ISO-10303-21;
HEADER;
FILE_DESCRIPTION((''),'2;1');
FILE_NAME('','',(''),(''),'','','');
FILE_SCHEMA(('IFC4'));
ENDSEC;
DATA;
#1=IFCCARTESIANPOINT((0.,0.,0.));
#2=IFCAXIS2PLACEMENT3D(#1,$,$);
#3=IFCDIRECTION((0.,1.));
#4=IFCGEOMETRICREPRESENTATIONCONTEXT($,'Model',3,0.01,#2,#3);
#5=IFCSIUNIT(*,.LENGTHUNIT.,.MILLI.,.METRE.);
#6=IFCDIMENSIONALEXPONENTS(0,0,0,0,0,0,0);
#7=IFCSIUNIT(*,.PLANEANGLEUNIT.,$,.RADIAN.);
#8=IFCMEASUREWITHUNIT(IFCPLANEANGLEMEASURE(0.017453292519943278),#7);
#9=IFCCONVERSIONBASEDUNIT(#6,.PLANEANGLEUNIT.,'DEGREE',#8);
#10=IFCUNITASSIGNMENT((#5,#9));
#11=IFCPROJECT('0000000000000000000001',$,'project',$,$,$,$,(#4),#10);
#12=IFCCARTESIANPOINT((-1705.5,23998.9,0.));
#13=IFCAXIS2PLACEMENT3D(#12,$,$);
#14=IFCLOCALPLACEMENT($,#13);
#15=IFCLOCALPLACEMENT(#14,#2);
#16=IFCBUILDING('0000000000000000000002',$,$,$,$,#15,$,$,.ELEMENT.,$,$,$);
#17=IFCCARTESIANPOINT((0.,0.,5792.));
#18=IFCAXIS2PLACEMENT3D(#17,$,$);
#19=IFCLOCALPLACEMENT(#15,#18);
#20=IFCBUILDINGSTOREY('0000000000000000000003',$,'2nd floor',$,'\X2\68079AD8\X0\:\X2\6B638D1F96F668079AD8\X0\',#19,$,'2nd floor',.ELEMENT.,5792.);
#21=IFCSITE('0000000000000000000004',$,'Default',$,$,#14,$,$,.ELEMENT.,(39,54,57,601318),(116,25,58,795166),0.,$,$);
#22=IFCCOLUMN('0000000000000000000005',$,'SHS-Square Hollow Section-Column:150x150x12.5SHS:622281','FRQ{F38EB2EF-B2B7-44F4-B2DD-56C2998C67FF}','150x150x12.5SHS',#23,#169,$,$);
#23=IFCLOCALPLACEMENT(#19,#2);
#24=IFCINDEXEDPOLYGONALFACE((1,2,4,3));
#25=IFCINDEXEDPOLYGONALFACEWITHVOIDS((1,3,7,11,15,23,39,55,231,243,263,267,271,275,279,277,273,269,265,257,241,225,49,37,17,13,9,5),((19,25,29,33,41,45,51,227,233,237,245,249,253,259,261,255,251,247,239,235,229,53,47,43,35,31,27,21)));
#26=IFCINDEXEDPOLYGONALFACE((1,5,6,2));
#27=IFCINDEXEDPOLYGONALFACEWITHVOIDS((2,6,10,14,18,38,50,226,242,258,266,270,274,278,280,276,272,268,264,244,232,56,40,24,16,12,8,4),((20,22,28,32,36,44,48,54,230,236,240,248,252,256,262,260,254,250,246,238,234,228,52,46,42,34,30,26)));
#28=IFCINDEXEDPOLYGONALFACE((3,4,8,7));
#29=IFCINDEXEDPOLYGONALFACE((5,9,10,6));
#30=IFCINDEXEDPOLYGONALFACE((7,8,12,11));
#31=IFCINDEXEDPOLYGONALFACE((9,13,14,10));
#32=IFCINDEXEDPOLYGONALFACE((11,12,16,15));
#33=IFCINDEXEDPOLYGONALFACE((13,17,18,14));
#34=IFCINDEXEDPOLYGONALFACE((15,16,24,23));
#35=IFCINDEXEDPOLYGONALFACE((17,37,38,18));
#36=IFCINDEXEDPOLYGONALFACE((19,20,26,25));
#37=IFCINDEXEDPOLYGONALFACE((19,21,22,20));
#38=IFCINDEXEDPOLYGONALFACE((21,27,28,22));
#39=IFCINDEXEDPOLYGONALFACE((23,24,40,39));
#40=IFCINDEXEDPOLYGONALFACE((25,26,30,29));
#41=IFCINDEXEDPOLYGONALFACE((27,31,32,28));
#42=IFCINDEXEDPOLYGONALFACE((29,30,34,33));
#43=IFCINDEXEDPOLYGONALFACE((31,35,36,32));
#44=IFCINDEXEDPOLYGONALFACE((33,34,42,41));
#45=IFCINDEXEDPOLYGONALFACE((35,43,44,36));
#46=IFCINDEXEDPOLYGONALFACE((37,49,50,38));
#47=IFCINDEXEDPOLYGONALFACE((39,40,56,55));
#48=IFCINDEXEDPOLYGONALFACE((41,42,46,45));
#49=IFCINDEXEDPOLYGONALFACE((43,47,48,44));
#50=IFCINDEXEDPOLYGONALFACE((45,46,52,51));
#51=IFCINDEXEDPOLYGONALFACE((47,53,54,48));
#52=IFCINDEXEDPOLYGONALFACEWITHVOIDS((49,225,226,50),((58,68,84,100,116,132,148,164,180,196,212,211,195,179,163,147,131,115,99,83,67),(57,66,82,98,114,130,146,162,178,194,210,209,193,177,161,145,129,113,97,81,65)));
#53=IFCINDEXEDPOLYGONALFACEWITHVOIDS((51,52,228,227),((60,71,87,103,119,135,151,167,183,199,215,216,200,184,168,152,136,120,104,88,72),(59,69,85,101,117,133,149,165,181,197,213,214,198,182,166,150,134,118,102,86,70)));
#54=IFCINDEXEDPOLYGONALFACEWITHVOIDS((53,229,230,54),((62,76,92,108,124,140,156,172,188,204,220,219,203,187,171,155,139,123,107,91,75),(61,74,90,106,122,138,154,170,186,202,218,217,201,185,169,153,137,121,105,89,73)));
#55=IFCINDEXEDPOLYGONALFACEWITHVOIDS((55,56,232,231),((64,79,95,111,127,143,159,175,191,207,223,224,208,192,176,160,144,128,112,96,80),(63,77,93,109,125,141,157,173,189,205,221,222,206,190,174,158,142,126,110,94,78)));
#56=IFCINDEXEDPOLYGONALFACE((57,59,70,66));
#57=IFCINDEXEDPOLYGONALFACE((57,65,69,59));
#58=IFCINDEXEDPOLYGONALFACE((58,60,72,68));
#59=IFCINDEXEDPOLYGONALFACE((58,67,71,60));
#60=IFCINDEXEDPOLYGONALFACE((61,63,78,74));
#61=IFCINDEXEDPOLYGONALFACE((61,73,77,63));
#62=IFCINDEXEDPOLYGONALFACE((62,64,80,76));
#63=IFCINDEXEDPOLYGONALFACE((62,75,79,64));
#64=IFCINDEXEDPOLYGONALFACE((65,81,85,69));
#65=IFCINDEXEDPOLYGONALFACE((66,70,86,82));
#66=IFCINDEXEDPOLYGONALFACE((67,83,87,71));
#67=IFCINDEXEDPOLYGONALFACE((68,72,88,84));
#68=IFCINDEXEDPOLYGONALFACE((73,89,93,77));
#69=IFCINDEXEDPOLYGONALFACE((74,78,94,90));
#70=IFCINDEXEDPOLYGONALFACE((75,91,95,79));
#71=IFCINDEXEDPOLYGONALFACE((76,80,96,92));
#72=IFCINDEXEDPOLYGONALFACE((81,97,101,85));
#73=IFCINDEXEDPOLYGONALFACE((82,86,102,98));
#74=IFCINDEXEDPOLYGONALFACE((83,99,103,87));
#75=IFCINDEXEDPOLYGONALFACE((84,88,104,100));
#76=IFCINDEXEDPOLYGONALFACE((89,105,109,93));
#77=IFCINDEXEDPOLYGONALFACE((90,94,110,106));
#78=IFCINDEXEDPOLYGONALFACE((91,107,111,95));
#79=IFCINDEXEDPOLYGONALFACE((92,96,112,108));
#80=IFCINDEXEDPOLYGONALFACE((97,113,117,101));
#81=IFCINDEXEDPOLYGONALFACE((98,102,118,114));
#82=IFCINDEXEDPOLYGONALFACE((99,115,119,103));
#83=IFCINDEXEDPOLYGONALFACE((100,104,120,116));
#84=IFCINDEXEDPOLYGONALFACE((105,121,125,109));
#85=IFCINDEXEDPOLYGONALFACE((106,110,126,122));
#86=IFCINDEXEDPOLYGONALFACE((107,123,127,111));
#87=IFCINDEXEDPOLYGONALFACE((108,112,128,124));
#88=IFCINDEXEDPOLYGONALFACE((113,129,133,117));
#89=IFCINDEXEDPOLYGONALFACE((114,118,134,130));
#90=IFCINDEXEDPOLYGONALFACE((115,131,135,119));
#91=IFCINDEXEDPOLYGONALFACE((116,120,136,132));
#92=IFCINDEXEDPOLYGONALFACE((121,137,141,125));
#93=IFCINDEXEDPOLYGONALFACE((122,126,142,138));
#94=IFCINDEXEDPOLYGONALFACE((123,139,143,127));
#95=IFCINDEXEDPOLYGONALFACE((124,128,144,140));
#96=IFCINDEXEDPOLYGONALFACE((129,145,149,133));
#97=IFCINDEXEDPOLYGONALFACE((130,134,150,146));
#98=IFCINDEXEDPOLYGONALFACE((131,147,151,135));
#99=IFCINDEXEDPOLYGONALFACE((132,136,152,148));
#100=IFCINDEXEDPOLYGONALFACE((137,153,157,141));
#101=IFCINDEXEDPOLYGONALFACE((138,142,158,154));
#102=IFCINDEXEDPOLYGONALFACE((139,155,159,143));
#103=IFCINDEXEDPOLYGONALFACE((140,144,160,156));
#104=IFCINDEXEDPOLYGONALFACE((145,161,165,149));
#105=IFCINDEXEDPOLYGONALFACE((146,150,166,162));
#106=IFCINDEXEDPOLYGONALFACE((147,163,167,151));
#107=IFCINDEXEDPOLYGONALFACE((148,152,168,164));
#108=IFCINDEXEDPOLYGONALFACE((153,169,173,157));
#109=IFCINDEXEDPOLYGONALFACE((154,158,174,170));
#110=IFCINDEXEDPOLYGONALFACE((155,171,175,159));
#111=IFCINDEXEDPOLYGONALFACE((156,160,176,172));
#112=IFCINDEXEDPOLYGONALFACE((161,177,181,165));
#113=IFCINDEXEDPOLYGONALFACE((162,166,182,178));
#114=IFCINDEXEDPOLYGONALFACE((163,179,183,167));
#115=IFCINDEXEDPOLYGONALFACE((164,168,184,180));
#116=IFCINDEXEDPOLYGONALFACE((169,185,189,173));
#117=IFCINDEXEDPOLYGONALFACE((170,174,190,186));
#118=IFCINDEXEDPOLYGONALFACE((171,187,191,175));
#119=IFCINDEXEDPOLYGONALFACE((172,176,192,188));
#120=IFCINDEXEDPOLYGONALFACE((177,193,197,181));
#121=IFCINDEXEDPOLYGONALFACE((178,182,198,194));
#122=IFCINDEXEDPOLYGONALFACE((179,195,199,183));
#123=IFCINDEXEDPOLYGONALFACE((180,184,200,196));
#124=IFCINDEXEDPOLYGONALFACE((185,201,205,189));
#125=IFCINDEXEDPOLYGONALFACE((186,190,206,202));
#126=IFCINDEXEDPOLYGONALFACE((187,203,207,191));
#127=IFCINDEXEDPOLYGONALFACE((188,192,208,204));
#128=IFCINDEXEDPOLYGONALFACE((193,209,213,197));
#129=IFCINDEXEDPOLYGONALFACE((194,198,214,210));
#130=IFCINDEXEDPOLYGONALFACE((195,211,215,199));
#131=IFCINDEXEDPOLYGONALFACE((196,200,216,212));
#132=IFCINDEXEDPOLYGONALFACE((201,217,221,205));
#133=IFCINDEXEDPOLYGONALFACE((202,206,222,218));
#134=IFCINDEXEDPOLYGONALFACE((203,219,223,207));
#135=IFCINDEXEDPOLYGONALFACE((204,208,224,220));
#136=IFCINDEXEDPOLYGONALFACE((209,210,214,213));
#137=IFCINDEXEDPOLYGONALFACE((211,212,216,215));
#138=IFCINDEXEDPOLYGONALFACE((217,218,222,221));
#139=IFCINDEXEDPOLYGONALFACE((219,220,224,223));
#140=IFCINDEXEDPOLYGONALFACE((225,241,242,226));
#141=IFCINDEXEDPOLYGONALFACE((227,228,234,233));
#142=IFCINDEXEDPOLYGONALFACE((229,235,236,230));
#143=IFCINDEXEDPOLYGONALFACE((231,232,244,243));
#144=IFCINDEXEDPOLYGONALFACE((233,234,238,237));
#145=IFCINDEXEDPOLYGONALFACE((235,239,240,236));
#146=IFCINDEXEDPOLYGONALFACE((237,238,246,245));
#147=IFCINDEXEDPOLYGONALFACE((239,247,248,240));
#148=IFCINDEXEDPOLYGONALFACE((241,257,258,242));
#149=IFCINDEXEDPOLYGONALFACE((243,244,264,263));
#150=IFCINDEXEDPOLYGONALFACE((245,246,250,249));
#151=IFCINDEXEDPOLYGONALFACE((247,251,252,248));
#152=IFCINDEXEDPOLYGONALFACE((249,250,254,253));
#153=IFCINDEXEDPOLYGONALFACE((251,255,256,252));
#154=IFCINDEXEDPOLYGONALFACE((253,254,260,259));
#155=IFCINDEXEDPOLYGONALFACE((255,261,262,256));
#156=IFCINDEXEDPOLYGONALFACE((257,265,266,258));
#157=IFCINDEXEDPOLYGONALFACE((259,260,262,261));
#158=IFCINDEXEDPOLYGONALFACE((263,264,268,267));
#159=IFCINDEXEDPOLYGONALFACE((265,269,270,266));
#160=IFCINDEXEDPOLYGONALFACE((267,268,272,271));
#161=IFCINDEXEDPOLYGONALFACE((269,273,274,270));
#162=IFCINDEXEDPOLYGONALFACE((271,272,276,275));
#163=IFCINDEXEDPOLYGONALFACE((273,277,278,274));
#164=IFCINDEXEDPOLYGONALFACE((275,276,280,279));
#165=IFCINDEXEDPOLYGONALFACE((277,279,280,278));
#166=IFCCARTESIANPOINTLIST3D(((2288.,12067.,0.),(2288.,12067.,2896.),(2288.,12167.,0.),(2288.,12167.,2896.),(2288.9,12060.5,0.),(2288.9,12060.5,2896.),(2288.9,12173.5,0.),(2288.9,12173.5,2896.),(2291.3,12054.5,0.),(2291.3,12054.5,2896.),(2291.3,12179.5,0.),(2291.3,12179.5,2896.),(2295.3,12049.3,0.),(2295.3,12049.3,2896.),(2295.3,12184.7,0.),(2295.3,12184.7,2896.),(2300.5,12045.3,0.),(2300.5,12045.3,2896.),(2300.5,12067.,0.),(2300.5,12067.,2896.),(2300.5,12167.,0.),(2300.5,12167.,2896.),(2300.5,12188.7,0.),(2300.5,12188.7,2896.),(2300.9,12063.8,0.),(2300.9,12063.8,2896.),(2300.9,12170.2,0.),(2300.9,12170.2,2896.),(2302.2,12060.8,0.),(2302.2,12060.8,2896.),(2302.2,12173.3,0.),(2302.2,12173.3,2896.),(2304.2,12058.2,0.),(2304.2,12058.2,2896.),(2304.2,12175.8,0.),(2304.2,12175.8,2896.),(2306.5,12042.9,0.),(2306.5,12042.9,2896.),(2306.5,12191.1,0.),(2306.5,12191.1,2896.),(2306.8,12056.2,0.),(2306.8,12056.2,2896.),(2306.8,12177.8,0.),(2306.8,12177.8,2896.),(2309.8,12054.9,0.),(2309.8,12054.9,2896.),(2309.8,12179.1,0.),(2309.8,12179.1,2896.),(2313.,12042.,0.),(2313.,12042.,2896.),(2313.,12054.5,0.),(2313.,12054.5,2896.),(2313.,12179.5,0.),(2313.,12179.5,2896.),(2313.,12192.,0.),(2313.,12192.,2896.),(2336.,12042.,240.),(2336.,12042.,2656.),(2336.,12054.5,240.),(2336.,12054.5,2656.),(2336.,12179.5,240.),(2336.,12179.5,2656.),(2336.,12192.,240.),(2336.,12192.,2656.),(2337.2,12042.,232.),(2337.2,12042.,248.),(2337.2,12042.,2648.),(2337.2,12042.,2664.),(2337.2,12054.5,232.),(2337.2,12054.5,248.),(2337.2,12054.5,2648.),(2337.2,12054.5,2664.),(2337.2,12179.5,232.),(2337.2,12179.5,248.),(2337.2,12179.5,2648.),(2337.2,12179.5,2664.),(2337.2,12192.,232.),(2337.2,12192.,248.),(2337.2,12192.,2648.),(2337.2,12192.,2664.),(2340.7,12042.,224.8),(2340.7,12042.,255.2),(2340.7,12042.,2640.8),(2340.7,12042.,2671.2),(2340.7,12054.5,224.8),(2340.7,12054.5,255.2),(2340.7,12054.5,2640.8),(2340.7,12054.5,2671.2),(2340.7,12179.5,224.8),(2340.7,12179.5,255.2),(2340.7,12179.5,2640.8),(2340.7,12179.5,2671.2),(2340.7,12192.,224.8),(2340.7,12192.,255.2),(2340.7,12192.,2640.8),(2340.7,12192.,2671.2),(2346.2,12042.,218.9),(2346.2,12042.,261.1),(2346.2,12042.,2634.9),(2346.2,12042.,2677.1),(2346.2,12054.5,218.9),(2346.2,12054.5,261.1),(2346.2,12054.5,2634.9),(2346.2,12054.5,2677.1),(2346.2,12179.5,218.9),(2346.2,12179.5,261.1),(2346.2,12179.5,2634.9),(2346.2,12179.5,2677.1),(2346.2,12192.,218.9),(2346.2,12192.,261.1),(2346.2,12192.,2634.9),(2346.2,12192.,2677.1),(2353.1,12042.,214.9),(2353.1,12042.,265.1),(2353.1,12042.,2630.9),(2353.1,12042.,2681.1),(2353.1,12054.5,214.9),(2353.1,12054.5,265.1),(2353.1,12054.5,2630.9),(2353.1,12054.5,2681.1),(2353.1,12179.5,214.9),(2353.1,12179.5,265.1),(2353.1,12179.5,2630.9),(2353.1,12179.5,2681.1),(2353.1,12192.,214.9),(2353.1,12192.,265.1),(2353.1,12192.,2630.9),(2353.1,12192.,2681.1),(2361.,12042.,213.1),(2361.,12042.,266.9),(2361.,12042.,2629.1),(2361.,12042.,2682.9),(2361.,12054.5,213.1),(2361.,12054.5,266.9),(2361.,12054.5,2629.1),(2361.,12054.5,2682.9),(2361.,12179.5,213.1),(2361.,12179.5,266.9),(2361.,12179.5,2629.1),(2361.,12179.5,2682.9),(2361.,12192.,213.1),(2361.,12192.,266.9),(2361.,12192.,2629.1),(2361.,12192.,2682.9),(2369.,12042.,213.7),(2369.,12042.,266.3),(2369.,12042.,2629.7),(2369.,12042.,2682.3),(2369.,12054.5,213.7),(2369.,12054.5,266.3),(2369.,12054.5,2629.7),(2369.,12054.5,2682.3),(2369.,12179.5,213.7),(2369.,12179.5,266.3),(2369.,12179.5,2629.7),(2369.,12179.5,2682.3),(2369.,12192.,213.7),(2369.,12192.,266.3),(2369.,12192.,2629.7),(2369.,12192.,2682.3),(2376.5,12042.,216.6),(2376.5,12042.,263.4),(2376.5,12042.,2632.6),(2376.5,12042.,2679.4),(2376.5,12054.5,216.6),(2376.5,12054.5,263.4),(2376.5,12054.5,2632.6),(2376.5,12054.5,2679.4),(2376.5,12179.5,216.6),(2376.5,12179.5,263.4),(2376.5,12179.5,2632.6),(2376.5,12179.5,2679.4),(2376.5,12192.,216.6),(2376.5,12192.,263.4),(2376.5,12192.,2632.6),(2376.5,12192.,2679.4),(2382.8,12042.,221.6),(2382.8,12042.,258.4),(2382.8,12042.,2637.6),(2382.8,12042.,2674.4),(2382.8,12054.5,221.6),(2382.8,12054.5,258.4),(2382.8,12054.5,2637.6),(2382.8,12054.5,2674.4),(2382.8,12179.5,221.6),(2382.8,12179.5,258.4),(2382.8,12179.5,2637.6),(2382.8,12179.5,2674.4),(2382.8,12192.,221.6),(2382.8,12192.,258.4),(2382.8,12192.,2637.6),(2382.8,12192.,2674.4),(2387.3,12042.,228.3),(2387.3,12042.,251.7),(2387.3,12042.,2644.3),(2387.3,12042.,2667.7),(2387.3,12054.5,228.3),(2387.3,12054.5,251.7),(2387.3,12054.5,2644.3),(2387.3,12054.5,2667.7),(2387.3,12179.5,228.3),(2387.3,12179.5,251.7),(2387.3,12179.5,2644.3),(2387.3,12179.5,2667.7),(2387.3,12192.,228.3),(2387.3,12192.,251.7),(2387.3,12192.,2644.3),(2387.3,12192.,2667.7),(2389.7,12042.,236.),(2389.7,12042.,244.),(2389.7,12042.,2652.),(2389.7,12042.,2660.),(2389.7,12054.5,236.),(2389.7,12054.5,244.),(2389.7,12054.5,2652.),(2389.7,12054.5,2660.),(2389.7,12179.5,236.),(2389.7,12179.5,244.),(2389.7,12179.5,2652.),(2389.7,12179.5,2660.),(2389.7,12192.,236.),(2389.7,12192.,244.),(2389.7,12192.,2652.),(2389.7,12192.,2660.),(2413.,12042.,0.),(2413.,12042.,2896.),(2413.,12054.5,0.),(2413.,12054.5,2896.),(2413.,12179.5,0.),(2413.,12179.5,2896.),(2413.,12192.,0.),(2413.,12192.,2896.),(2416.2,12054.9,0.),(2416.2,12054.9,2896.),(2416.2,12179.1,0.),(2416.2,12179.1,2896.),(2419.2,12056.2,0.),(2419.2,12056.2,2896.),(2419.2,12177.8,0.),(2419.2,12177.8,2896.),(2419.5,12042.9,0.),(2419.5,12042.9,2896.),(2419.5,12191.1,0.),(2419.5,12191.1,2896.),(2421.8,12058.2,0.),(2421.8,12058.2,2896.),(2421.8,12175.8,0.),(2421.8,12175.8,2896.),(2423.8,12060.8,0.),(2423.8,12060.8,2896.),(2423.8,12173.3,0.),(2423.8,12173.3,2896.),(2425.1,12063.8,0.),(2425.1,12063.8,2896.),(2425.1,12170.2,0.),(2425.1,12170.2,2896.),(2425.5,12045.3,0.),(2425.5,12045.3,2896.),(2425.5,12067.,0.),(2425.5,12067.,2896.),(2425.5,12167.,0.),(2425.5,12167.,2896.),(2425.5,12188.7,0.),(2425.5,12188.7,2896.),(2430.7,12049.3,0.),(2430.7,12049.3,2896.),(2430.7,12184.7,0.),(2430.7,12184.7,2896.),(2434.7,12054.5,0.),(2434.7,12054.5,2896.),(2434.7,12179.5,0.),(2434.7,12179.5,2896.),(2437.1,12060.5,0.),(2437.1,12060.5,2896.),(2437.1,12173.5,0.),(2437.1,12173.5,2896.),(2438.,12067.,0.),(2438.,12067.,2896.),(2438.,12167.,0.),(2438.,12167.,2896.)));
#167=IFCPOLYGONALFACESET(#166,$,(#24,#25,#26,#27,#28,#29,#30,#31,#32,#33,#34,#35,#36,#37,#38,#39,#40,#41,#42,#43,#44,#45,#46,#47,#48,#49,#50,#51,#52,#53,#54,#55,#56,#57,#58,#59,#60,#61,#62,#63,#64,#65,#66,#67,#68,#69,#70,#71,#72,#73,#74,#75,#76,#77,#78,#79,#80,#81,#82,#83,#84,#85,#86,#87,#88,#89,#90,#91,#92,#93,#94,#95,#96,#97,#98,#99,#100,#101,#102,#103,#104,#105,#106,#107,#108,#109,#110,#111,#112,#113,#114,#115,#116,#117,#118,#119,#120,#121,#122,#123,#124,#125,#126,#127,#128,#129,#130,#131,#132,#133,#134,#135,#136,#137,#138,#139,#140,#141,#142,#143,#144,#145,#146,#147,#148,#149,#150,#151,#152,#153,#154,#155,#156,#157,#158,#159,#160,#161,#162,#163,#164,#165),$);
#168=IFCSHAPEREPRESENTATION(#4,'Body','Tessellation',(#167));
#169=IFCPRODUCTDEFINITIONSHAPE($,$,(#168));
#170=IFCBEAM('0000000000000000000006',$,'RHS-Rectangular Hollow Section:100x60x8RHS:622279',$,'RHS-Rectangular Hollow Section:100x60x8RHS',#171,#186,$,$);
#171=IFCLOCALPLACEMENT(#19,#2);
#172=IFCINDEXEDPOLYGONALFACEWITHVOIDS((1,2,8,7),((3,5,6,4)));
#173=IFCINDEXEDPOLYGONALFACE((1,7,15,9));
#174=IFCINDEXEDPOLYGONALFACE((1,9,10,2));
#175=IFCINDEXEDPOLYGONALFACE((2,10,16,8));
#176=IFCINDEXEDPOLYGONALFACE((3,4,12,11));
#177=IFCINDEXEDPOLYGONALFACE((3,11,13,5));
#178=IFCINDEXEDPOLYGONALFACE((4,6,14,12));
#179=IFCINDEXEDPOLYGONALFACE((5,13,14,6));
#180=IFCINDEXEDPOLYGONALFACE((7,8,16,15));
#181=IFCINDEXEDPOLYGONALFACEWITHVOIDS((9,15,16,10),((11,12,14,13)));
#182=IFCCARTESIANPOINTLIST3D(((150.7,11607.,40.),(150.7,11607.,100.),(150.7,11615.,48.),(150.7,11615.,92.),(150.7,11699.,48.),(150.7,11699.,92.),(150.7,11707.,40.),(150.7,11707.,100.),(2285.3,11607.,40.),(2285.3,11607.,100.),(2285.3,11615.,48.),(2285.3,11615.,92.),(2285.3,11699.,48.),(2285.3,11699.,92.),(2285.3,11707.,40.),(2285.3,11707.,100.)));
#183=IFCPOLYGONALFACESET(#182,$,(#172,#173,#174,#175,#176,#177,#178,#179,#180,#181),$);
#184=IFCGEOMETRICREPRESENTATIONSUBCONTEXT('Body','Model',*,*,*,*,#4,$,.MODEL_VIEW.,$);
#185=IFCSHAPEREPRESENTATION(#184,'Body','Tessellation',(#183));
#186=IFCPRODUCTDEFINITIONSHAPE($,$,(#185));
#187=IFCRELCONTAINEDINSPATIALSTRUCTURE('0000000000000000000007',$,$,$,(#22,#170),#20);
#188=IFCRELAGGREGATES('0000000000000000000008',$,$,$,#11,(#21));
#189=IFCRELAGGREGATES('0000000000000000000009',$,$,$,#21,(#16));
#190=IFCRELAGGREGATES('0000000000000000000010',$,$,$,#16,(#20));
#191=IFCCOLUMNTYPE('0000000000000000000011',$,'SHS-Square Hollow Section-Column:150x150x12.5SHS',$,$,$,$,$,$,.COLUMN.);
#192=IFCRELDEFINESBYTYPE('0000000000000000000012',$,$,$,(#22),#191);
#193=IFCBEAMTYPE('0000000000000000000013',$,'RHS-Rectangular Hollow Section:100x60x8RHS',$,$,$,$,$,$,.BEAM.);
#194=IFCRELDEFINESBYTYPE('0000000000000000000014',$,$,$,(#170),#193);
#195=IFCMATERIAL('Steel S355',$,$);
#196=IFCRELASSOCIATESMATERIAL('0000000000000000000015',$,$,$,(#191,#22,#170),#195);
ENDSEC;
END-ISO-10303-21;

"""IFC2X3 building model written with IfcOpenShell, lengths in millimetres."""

from ifc_helpers import new_model, entity, si_unit, converted_unit, direction, frame, frame_2d, origin, origin_2d, place, context, subcontext, project, spatial, circle_curve, rectangle, hollow_rectangle, outline, extrude, boolean, material, type_object, element, save


model = new_model("IFC2X3")

# Units and contexts
model_context = context("Model", 3, precision=0.01, world=origin(), true_north=direction((0.0, 1.0)))
body_context = subcontext(model_context, "Body", "Model", "MODEL_VIEW")
ifc_project = project(units=[si_unit("LENGTHUNIT", "METRE", prefix="MILLI"), converted_unit("PLANEANGLEUNIT", "DEGREE", entity("IfcPlaneAngleMeasure", 0.017453292519943278), si_unit("PLANEANGLEUNIT", "RADIAN"), dimensions=[0, 0, 0, 0, 0, 0, 0])], contexts=[model_context])

# Site, building, storey
site_placement = place(None, frame((-1705.5, 23998.9, 0.0)))
site = spatial("IfcSite", under=ifc_project, at=site_placement, Name="Default", CompositionType="ELEMENT", RefLatitude=(39, 54, 57, 601318), RefLongitude=(116, 25, 58, 795166), RefElevation=0.0)
building_placement = place(site_placement, origin())
building = spatial("IfcBuilding", under=site, at=building_placement, CompositionType="ELEMENT")
storey_placement = place(building_placement, frame((0.0, 0.0, 5792.0)))
storey = spatial("IfcBuildingStorey", under=building, at=storey_placement, Name="2nd floor", ObjectType="标高:正负零标高", LongName="2nd floor", CompositionType="ELEMENT", Elevation=5792.0)

# Shared definitions
ifc_material_1 = material(Name="Steel S355")

# Column, openings
column_type_1 = type_object("IfcColumnType", Name="SHS-Square Hollow Section-Column:150x150x12.5SHS", PredefinedType="COLUMN", material=ifc_material_1)
column_1_placement = place(storey_placement, frame((2363.0, 12117.0, 2896.0), z_axis=(0.0, 0.0, 1.0), x_axis=(0.0, -1.0, 0.0)))
column_1 = element("IfcColumn", 1, at=column_1_placement, inside=storey, type_object=column_type_1, material=ifc_material_1, Name="SHS-Square Hollow Section-Column:150x150x12.5SHS:622281", Description="FRQ{F38EB2EF-B2B7-44F4-B2DD-56C2998C67FF}", ObjectType="150x150x12.5SHS", context=model_context, shape_type="SweptSolid", body=[
    extrude(hollow_rectangle(XDim=150.0, YDim=150.0, WallThickness=12.5, InnerFilletRadius=12.5, OuterFilletRadius=25.0, at=origin_2d()), origin(), (0.0, 0.0, -1.0), 2896.0),
])
opening_1_placement = place(column_1_placement, frame((175.1, 0.0, 0.0), z_axis=(-1.0, 0.0, 0.0), x_axis=(0.0, -1.0, 0.0)))
element("IfcOpeningElement", 2, at=opening_1_placement, cuts=column_1, ObjectType="Opening", context=model_context, shape_type="SweptSolid", body=[
    extrude(outline(circle_curve(frame_2d((0.0, -240.0), x_axis=(1.0, 0.0)), 27.0)), origin(), (0.0, 0.0, 1.0), 350.2),
])
opening_2_placement = place(column_1_placement, frame((175.1, 0.0, -2896.0), z_axis=(-1.0, 0.0, 0.0), x_axis=(0.0, -1.0, 0.0)))
element("IfcOpeningElement", 3, at=opening_2_placement, cuts=column_1, ObjectType="Opening", context=model_context, shape_type="SweptSolid", body=[
    extrude(outline(circle_curve(frame_2d((0.0, 240.0), x_axis=(1.0, 0.0)), 27.0)), origin(), (0.0, 0.0, 1.0), 350.2),
])

# Beam
beam_type_1 = type_object("IfcBeamType", Name="RHS-Rectangular Hollow Section:100x60x8RHS", PredefinedType="BEAM")
beam_1_placement = place(storey_placement, frame((150.7, 11707.0, 70.0)))
element("IfcBeam", 4, at=beam_1_placement, inside=storey, type_object=beam_type_1, material=ifc_material_1, Name="RHS-Rectangular Hollow Section:100x60x8RHS:622279", ObjectType="RHS-Rectangular Hollow Section:100x60x8RHS", context=body_context, shape_type="SweptSolid", body=[
    boolean("DIFFERENCE", extrude(rectangle(XDim=60.0, YDim=100.0, at=frame_2d((0.0, 0.0), x_axis=(1.0, 0.0))), frame((0.0, -50.0, 0.0), z_axis=(1.0, 0.0, 0.0), x_axis=(0.0, 0.0, -1.0)), (0.0, 0.0, 1.0), 2134.6), extrude(rectangle(XDim=44.0, YDim=84.0, at=frame_2d((0.0, 0.0), x_axis=(0.0, 1.0))), frame((2134.6, -50.0, 0.0), z_axis=(-1.0, 0.0, 0.0), x_axis=(0.0, 1.0, 0.0)), (0.0, 0.0, 1.0), 2134.6)),
])

save(model, "model.ifc")
